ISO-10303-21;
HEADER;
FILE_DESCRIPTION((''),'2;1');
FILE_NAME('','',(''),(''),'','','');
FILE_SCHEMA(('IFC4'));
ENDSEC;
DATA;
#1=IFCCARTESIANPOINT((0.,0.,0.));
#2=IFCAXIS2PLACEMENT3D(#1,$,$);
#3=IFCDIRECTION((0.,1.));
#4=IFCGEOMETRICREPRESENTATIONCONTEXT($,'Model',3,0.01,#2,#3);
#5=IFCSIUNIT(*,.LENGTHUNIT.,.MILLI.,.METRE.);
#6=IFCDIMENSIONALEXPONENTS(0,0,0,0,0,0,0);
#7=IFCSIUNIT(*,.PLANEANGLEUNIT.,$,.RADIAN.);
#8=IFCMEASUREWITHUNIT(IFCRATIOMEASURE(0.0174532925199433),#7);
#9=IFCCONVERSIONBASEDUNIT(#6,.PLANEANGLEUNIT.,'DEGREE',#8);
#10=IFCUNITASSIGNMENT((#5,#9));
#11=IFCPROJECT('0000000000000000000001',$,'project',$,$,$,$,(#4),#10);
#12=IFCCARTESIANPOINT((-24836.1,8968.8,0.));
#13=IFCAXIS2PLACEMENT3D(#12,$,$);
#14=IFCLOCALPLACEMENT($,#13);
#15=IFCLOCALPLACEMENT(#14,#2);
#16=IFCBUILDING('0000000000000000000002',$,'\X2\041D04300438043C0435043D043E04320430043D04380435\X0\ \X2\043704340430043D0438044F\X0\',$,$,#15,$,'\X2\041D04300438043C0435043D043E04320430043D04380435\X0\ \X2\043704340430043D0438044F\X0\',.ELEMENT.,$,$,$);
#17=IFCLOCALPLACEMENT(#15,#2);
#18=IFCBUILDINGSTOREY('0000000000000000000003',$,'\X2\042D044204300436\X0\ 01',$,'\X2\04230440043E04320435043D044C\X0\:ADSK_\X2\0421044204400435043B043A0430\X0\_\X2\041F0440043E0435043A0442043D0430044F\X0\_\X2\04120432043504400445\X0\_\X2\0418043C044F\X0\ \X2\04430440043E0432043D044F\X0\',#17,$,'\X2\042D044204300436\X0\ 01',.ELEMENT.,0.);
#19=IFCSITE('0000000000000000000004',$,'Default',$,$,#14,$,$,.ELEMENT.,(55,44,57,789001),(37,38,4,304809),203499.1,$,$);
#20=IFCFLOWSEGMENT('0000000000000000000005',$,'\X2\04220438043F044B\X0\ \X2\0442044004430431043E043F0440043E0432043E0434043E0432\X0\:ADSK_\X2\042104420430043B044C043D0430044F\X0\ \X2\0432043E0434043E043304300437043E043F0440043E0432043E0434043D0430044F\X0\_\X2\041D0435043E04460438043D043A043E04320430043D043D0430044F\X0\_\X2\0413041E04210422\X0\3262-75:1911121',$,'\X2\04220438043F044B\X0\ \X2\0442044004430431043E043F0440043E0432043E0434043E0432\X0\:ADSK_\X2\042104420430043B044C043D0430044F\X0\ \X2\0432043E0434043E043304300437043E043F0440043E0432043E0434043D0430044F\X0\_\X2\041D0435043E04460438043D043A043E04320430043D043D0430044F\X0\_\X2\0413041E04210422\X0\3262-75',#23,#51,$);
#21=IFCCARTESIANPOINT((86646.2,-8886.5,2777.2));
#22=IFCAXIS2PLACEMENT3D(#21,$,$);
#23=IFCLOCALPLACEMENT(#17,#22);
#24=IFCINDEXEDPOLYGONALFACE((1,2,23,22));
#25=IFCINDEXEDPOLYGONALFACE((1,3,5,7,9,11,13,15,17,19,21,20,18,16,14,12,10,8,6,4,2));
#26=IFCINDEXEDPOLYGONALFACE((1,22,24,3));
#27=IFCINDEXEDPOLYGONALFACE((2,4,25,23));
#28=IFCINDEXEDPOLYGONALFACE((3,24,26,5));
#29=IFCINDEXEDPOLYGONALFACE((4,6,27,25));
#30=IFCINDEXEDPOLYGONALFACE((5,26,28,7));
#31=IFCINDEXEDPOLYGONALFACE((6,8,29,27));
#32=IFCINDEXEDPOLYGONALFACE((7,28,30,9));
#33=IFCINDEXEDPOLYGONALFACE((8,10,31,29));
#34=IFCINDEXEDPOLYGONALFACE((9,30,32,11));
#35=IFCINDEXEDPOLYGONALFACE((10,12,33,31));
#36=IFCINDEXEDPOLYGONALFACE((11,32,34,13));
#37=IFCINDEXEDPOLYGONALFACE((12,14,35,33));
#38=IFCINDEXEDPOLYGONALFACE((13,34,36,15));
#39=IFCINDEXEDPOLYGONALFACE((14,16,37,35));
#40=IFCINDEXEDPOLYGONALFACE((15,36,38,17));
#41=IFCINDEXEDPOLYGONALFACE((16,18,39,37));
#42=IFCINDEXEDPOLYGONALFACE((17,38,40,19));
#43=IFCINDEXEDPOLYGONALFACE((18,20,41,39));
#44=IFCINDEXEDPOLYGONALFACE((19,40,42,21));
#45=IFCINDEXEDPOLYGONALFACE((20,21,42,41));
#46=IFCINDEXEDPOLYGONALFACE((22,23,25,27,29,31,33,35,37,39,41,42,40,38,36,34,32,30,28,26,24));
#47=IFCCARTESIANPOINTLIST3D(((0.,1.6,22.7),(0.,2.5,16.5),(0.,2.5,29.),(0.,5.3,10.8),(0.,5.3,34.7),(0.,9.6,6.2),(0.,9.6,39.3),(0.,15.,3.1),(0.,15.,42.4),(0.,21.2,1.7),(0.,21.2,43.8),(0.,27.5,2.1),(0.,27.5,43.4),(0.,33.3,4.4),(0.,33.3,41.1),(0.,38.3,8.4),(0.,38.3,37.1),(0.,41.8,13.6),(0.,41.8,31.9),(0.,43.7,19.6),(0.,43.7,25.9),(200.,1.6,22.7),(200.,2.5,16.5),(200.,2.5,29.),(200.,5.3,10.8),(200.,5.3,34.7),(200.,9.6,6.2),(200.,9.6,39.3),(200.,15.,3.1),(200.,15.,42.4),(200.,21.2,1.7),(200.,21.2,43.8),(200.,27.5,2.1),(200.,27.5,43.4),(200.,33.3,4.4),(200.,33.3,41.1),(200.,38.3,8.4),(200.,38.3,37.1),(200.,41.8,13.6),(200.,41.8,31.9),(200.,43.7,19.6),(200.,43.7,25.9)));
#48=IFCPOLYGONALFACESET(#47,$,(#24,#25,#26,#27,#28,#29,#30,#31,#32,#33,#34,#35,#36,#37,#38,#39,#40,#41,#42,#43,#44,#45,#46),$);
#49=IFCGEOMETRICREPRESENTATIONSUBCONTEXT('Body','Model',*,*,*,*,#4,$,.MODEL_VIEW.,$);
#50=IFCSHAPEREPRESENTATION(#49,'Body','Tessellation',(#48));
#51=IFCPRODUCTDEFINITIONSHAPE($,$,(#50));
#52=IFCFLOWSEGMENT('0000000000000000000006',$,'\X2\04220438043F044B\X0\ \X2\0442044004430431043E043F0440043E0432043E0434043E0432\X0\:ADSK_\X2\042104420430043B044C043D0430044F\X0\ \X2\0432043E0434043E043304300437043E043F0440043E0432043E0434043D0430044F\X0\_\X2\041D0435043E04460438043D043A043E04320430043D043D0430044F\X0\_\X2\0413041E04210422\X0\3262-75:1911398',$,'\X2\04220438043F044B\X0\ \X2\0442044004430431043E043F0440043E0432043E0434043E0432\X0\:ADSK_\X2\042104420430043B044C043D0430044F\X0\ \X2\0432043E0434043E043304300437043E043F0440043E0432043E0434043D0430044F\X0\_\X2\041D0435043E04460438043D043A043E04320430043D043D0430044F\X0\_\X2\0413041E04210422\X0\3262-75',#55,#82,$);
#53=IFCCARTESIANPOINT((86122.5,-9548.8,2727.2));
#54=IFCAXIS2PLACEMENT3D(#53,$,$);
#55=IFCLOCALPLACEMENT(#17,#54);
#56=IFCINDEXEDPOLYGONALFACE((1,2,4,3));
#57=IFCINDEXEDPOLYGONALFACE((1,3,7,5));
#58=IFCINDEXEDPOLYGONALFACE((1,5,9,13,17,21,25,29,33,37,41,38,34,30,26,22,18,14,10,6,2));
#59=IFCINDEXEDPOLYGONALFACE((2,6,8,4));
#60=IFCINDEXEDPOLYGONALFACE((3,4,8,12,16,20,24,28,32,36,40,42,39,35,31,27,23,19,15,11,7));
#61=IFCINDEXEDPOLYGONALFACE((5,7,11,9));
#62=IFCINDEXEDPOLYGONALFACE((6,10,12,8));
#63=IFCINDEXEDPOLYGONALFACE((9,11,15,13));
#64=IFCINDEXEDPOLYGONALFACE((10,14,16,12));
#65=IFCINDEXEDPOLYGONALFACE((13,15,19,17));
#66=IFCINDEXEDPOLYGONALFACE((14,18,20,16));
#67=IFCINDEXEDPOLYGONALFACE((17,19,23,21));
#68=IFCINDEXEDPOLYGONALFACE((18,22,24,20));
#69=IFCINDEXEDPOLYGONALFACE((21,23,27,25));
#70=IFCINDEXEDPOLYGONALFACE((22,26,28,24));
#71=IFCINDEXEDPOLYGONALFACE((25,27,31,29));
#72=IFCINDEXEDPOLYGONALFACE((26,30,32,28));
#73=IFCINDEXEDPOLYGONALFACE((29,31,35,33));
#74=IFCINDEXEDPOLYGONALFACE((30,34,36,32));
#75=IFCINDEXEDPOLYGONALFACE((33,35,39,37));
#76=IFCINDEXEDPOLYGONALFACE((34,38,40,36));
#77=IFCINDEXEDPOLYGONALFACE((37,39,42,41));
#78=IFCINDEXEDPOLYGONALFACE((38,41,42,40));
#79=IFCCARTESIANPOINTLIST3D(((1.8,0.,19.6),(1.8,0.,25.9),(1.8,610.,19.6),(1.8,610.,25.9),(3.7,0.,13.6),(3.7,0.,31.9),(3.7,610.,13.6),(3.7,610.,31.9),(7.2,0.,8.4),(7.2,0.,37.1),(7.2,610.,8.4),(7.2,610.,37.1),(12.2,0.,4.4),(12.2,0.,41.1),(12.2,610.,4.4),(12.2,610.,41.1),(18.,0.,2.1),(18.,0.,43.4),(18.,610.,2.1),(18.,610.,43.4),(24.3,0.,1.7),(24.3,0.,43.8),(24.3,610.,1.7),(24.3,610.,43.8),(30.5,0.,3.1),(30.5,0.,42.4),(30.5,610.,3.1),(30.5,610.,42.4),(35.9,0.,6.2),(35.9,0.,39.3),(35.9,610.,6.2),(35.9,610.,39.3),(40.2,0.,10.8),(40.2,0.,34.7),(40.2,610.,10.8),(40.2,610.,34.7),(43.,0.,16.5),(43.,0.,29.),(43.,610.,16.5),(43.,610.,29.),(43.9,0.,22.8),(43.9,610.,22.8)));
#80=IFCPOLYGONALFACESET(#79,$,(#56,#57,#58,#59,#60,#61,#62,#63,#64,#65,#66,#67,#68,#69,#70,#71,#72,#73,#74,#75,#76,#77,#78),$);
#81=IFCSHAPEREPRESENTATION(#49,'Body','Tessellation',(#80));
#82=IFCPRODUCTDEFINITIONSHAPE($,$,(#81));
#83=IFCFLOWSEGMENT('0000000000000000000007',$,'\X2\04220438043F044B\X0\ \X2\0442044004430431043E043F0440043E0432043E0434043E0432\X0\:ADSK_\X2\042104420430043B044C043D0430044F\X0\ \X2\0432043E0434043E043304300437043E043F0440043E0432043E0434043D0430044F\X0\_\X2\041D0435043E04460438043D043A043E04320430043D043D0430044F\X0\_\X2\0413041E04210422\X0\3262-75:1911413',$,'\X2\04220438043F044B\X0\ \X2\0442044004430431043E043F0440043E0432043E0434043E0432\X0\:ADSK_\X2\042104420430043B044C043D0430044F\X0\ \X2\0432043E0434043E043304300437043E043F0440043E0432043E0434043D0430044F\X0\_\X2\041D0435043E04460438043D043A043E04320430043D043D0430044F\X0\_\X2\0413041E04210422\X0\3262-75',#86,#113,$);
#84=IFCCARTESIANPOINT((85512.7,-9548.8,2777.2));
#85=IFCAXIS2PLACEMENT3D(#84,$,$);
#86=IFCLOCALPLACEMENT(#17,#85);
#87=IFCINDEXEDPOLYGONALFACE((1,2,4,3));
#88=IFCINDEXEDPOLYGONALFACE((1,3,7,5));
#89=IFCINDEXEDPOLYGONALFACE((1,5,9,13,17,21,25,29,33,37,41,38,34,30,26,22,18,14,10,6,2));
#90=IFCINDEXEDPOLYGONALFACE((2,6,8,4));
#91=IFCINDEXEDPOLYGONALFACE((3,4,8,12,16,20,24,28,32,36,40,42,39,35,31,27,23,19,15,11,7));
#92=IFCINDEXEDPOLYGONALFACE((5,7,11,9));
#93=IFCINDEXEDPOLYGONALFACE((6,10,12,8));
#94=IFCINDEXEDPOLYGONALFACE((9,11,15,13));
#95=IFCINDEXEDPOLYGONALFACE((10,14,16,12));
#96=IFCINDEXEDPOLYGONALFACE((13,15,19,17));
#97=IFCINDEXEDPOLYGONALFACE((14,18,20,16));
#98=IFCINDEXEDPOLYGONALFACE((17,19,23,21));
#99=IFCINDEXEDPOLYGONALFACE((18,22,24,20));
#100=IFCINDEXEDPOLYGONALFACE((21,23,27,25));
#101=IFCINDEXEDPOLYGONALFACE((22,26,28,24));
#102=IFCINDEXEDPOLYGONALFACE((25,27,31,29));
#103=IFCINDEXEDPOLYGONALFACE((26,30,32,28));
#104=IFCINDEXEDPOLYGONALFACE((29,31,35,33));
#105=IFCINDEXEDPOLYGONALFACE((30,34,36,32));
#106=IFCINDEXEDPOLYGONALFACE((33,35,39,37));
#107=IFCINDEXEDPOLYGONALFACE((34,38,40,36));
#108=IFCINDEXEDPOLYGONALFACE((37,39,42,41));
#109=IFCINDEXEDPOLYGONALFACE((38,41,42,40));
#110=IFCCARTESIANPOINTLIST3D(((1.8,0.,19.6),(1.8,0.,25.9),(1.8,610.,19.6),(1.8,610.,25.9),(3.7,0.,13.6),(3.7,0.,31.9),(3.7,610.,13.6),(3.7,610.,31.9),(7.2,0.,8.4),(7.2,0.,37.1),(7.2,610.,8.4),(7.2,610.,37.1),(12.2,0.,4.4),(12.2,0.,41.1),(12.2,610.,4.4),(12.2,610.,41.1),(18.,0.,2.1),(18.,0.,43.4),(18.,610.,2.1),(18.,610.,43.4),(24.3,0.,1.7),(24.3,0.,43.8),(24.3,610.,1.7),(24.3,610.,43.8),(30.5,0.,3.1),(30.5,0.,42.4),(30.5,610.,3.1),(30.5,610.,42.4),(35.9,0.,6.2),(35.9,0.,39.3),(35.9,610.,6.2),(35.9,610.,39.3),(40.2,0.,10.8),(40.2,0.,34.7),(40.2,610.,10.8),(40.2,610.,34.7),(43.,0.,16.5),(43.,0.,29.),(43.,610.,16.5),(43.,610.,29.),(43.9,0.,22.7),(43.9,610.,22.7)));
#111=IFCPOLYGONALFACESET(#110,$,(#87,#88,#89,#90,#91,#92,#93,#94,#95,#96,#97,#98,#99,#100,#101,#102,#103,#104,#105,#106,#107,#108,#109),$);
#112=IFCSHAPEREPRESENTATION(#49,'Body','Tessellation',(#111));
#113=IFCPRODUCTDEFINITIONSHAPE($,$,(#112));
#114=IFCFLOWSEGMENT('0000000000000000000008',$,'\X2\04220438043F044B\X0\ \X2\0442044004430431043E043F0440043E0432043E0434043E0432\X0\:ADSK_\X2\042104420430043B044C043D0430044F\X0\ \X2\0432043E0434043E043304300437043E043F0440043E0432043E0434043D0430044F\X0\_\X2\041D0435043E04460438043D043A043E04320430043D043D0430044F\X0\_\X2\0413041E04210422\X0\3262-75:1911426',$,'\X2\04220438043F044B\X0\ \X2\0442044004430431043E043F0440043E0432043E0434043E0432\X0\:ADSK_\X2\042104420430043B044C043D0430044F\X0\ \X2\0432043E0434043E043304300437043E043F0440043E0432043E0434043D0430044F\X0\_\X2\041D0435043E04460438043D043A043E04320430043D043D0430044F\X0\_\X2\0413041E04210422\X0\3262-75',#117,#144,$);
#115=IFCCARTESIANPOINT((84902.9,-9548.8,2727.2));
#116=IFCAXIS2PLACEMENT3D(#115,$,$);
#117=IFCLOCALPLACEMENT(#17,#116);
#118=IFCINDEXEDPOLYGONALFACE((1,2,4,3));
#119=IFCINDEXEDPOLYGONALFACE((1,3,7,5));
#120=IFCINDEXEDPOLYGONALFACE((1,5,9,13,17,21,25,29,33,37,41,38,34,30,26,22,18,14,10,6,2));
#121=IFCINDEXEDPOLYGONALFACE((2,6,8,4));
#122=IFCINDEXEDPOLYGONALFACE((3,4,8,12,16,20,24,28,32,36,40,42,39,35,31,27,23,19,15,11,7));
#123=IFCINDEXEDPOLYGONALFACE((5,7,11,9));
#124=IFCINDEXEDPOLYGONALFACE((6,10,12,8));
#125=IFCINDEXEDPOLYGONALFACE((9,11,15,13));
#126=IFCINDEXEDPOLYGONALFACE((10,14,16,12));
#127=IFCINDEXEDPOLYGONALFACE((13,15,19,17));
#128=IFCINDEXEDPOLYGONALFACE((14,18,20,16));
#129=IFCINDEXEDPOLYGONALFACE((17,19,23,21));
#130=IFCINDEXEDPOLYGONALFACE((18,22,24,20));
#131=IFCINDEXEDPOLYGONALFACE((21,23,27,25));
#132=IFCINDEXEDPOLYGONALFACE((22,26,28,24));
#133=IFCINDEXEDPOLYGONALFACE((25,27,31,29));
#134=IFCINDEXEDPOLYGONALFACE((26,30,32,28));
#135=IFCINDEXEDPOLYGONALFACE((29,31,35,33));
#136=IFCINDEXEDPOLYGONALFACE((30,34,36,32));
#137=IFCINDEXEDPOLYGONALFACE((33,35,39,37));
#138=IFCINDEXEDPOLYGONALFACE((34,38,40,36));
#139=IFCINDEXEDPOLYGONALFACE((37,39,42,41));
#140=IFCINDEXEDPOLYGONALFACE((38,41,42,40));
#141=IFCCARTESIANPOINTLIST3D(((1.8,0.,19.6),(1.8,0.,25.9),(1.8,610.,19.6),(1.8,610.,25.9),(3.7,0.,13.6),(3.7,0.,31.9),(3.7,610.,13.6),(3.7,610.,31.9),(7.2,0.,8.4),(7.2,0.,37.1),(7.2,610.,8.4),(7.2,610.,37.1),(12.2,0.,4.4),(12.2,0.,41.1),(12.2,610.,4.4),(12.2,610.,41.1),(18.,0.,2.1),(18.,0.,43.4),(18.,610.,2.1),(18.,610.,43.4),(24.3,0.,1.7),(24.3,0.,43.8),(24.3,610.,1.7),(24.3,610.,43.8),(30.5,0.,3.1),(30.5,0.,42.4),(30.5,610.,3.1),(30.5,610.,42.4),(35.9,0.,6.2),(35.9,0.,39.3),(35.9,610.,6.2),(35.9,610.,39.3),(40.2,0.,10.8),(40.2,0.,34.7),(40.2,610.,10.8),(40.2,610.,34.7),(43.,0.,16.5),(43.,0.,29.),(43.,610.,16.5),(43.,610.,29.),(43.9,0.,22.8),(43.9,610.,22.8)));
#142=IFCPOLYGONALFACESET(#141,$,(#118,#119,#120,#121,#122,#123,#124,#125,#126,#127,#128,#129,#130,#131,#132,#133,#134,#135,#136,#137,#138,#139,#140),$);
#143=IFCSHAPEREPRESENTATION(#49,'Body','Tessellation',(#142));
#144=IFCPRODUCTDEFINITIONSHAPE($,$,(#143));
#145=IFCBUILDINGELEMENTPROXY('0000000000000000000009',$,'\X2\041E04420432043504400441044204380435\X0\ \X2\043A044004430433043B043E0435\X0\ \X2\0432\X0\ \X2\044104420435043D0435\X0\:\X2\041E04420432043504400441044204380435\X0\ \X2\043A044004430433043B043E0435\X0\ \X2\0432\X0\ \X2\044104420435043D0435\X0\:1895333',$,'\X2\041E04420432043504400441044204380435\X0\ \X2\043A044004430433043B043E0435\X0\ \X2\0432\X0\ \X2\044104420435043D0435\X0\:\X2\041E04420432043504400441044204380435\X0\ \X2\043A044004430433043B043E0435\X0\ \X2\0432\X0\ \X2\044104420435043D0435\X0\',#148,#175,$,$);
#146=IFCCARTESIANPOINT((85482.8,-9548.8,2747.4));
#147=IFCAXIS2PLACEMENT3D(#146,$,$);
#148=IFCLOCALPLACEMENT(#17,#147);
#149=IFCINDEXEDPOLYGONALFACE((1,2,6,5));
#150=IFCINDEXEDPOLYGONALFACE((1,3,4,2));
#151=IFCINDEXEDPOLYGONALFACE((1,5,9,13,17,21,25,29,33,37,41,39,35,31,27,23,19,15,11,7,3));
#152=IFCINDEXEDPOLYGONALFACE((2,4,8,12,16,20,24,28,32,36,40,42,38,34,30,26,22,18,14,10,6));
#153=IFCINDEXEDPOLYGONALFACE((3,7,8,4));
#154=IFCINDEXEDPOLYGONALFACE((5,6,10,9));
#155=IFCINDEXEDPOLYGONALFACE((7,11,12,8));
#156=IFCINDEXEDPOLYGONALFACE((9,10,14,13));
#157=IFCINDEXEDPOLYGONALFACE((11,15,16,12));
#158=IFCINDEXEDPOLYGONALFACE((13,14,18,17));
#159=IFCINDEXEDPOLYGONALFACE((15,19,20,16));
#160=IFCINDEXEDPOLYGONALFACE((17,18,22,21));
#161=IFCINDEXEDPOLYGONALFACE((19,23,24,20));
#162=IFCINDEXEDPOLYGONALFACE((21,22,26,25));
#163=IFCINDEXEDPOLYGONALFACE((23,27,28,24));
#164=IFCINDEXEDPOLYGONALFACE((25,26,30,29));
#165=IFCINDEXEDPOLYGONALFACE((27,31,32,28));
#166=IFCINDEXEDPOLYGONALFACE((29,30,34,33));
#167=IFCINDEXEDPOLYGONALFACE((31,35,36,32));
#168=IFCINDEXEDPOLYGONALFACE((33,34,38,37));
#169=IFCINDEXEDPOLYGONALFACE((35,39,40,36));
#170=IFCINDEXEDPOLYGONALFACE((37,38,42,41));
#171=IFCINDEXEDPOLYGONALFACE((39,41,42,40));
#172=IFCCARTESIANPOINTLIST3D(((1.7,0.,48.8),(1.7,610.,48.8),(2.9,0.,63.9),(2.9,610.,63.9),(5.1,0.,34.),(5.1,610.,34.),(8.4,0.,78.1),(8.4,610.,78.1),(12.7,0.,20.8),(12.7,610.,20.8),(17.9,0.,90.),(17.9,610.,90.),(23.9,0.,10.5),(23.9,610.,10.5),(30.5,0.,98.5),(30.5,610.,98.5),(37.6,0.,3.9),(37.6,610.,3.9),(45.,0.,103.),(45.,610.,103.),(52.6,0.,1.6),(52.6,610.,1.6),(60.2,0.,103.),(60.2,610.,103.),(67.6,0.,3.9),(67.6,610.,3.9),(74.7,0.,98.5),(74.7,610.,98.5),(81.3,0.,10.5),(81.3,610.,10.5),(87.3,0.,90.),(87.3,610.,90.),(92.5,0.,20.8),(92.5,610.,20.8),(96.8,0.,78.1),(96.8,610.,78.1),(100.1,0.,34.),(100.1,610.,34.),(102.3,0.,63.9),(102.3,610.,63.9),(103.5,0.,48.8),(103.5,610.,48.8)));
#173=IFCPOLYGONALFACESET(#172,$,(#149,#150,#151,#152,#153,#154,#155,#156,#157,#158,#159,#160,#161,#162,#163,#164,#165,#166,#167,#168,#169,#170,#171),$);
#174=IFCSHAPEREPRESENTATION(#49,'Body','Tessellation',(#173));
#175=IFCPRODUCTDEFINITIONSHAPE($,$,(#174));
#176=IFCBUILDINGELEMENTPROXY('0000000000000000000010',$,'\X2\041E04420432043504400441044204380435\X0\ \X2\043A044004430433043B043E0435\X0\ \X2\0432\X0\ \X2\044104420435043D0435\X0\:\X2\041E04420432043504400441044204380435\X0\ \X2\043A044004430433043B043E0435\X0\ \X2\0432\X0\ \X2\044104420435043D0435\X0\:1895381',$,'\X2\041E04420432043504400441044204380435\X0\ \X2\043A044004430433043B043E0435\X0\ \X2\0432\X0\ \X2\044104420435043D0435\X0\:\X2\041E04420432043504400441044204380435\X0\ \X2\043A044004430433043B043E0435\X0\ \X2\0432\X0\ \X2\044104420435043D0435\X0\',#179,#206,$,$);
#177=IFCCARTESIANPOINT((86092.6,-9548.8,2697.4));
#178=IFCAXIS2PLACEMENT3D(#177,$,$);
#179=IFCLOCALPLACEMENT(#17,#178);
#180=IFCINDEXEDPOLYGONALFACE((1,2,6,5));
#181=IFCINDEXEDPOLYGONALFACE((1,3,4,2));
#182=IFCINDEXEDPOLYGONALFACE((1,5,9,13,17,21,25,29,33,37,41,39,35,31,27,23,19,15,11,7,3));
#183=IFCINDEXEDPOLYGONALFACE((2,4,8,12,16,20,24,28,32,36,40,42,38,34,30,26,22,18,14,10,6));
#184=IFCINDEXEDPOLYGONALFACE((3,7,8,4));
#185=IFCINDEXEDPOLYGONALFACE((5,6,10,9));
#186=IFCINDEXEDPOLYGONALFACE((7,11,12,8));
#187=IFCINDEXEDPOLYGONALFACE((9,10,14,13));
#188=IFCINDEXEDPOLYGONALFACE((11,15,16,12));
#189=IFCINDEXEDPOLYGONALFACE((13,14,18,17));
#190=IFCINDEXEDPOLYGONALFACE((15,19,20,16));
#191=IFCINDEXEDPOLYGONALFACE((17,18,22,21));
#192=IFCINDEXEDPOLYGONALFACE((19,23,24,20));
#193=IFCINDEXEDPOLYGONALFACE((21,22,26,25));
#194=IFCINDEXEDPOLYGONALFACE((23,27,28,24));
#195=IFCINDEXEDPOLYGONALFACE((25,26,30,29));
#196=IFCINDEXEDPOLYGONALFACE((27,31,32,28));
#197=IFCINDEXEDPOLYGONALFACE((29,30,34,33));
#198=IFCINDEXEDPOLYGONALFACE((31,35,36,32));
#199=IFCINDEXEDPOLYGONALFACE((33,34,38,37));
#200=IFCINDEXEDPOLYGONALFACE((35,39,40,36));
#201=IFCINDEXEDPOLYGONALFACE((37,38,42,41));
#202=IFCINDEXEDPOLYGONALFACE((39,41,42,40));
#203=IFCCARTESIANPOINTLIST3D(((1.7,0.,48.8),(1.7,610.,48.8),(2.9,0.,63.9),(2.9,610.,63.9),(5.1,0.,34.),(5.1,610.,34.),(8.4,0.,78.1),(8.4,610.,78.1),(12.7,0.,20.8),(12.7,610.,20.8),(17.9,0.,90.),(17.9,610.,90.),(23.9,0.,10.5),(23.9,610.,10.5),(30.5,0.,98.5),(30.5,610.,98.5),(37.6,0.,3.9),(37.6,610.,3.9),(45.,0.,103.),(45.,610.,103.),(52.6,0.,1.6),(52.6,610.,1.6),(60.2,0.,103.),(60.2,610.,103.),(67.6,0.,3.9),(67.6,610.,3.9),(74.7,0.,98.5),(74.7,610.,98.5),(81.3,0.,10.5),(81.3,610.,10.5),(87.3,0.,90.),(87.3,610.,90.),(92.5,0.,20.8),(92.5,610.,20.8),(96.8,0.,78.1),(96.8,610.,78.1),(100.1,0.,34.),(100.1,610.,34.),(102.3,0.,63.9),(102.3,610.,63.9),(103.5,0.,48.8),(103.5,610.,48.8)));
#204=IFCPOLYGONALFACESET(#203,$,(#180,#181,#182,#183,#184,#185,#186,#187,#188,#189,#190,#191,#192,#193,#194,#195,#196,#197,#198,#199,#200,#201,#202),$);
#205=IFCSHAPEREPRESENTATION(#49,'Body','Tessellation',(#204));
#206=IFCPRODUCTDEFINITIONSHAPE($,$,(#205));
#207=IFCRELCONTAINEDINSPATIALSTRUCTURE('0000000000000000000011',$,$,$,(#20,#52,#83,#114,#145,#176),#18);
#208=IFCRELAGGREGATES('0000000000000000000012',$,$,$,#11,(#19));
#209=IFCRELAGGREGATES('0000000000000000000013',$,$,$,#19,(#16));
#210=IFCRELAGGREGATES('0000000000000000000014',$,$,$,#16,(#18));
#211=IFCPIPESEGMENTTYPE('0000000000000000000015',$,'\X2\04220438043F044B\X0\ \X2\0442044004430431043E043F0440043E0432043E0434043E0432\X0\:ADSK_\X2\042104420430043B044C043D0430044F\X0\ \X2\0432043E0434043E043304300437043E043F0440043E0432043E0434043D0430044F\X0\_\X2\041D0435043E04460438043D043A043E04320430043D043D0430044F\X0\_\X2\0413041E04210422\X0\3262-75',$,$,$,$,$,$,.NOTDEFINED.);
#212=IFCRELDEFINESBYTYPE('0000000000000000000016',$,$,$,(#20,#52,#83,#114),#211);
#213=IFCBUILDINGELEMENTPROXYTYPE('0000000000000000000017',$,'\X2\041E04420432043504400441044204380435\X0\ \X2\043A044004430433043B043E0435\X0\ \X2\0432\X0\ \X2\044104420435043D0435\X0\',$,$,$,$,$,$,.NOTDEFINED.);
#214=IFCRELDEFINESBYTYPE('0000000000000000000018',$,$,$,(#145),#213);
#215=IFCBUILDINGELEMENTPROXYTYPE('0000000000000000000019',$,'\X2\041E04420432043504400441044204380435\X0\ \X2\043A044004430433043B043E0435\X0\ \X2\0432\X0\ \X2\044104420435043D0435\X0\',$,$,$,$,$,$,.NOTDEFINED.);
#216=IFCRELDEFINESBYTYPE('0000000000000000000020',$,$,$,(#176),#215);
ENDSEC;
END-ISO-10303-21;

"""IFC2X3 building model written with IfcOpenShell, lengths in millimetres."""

from ifc_helpers import new_model, entity, si_unit, converted_unit, direction, frame, origin, origin_2d_with_axis, place, context, subcontext, project, spatial, circle, extrude, type_object, element, save


model = new_model("IFC2X3")

# Units and contexts
model_context = context("Model", 3, precision=0.01, world=origin(), true_north=direction((0.0, 1.0)))
body_context = subcontext(model_context, "Body", "Model", "MODEL_VIEW")
ifc_project = project(units=[si_unit("LENGTHUNIT", "METRE", prefix="MILLI"), converted_unit("PLANEANGLEUNIT", "DEGREE", entity("IfcRatioMeasure", 0.0174532925199433), si_unit("PLANEANGLEUNIT", "RADIAN"), dimensions=[0, 0, 0, 0, 0, 0, 0])], contexts=[model_context])

# Site, building, storey
site_placement = place(None, frame((-24836.1, 8968.8, 0.0)))
site = spatial("IfcSite", under=ifc_project, at=site_placement, Name="Default", CompositionType="ELEMENT", RefLatitude=(55, 44, 57, 789001), RefLongitude=(37, 38, 4, 304809), RefElevation=203499.1)
building_placement = place(site_placement, origin())
building = spatial("IfcBuilding", under=site, at=building_placement, Name="Наименование здания", LongName="Наименование здания", CompositionType="ELEMENT")
storey_placement = place(building_placement, origin())
storey = spatial("IfcBuildingStorey", under=building, at=storey_placement, Name="Этаж 01", ObjectType="Уровень:ADSK_Стрелка_Проектная_Вверх_Имя уровня", LongName="Этаж 01", CompositionType="ELEMENT", Elevation=0.0)

# Flow segments
pipe_segment_type_1 = type_object("IfcPipeSegmentType", Name="Типы трубопроводов:ADSK_Стальная водогазопроводная_Неоцинкованная_ГОСТ3262-75", PredefinedType="NOTDEFINED")
flow_segment_1_placement = place(storey_placement, frame((86646.2, -8886.5, 2777.2)))
element("IfcFlowSegment", 1, at=flow_segment_1_placement, inside=storey, type_object=pipe_segment_type_1, Name="Типы трубопроводов:ADSK_Стальная водогазопроводная_Неоцинкованная_ГОСТ3262-75:1911121", ObjectType="Типы трубопроводов:ADSK_Стальная водогазопроводная_Неоцинкованная_ГОСТ3262-75", context=body_context, shape_type="SweptSolid", body=[
    extrude(circle(Radius=21.1, at=origin_2d_with_axis()), frame((0.0, 22.8, 22.8), z_axis=(1.0, 0.0, 0.0), x_axis=(0.0, -1.0, 0.0)), (0.0, 0.0, 1.0), 200.0),
])
for number, where, name in (
    (2, (86122.5, -9548.8, 2727.2), "Типы трубопроводов:ADSK_Стальная водогазопроводная_Неоцинкованная_ГОСТ3262-75:1911398"),
    (3, (85512.7, -9548.8, 2777.2), "Типы трубопроводов:ADSK_Стальная водогазопроводная_Неоцинкованная_ГОСТ3262-75:1911413"),
    (4, (84902.9, -9548.8, 2727.2), "Типы трубопроводов:ADSK_Стальная водогазопроводная_Неоцинкованная_ГОСТ3262-75:1911426"),
):
    element("IfcFlowSegment", number, at=place(storey_placement, frame(where)), inside=storey, type_object=pipe_segment_type_1, Name=name, ObjectType="Типы трубопроводов:ADSK_Стальная водогазопроводная_Неоцинкованная_ГОСТ3262-75", context=body_context, shape_type="SweptSolid", body=[
        extrude(circle(Radius=21.1, at=origin_2d_with_axis()), frame((22.8, 0.0, 22.8), z_axis=(0.0, 1.0, 0.0), x_axis=(1.0, 0.0, 0.0)), (0.0, 0.0, 1.0), 610.0),
    ])

# Building element proxies
building_element_proxy_type_1 = type_object("IfcBuildingElementProxyType", Name="Отверстие круглое в стене", PredefinedType="NOTDEFINED")
proxy_1_placement = place(storey_placement, frame((85482.8, -9548.8, 2747.4)))
element("IfcBuildingElementProxy", 5, at=proxy_1_placement, inside=storey, type_object=building_element_proxy_type_1, Name="Отверстие круглое в стене:Отверстие круглое в стене:1895333", ObjectType="Отверстие круглое в стене:Отверстие круглое в стене", context=body_context, shape_type="SweptSolid", body=[
    extrude(circle(Radius=51.0, at=origin_2d_with_axis()), frame((52.6, 0.0, 52.6), z_axis=(0.0, 1.0, 0.0), x_axis=(0.0, 0.0, -1.0)), (0.0, 0.0, 1.0), 610.0),
])
building_element_proxy_type_2 = type_object("IfcBuildingElementProxyType", Name="Отверстие круглое в стене", PredefinedType="NOTDEFINED")
proxy_2_placement = place(storey_placement, frame((86092.6, -9548.8, 2697.4)))
element("IfcBuildingElementProxy", 6, at=proxy_2_placement, inside=storey, type_object=building_element_proxy_type_2, Name="Отверстие круглое в стене:Отверстие круглое в стене:1895381", ObjectType="Отверстие круглое в стене:Отверстие круглое в стене", context=body_context, shape_type="SweptSolid", body=[
    extrude(circle(Radius=51.0, at=origin_2d_with_axis()), frame((52.6, 0.0, 52.6), z_axis=(0.0, 1.0, 0.0), x_axis=(0.0, 0.0, -1.0)), (0.0, 0.0, 1.0), 610.0),
])

save(model, "model.ifc")
